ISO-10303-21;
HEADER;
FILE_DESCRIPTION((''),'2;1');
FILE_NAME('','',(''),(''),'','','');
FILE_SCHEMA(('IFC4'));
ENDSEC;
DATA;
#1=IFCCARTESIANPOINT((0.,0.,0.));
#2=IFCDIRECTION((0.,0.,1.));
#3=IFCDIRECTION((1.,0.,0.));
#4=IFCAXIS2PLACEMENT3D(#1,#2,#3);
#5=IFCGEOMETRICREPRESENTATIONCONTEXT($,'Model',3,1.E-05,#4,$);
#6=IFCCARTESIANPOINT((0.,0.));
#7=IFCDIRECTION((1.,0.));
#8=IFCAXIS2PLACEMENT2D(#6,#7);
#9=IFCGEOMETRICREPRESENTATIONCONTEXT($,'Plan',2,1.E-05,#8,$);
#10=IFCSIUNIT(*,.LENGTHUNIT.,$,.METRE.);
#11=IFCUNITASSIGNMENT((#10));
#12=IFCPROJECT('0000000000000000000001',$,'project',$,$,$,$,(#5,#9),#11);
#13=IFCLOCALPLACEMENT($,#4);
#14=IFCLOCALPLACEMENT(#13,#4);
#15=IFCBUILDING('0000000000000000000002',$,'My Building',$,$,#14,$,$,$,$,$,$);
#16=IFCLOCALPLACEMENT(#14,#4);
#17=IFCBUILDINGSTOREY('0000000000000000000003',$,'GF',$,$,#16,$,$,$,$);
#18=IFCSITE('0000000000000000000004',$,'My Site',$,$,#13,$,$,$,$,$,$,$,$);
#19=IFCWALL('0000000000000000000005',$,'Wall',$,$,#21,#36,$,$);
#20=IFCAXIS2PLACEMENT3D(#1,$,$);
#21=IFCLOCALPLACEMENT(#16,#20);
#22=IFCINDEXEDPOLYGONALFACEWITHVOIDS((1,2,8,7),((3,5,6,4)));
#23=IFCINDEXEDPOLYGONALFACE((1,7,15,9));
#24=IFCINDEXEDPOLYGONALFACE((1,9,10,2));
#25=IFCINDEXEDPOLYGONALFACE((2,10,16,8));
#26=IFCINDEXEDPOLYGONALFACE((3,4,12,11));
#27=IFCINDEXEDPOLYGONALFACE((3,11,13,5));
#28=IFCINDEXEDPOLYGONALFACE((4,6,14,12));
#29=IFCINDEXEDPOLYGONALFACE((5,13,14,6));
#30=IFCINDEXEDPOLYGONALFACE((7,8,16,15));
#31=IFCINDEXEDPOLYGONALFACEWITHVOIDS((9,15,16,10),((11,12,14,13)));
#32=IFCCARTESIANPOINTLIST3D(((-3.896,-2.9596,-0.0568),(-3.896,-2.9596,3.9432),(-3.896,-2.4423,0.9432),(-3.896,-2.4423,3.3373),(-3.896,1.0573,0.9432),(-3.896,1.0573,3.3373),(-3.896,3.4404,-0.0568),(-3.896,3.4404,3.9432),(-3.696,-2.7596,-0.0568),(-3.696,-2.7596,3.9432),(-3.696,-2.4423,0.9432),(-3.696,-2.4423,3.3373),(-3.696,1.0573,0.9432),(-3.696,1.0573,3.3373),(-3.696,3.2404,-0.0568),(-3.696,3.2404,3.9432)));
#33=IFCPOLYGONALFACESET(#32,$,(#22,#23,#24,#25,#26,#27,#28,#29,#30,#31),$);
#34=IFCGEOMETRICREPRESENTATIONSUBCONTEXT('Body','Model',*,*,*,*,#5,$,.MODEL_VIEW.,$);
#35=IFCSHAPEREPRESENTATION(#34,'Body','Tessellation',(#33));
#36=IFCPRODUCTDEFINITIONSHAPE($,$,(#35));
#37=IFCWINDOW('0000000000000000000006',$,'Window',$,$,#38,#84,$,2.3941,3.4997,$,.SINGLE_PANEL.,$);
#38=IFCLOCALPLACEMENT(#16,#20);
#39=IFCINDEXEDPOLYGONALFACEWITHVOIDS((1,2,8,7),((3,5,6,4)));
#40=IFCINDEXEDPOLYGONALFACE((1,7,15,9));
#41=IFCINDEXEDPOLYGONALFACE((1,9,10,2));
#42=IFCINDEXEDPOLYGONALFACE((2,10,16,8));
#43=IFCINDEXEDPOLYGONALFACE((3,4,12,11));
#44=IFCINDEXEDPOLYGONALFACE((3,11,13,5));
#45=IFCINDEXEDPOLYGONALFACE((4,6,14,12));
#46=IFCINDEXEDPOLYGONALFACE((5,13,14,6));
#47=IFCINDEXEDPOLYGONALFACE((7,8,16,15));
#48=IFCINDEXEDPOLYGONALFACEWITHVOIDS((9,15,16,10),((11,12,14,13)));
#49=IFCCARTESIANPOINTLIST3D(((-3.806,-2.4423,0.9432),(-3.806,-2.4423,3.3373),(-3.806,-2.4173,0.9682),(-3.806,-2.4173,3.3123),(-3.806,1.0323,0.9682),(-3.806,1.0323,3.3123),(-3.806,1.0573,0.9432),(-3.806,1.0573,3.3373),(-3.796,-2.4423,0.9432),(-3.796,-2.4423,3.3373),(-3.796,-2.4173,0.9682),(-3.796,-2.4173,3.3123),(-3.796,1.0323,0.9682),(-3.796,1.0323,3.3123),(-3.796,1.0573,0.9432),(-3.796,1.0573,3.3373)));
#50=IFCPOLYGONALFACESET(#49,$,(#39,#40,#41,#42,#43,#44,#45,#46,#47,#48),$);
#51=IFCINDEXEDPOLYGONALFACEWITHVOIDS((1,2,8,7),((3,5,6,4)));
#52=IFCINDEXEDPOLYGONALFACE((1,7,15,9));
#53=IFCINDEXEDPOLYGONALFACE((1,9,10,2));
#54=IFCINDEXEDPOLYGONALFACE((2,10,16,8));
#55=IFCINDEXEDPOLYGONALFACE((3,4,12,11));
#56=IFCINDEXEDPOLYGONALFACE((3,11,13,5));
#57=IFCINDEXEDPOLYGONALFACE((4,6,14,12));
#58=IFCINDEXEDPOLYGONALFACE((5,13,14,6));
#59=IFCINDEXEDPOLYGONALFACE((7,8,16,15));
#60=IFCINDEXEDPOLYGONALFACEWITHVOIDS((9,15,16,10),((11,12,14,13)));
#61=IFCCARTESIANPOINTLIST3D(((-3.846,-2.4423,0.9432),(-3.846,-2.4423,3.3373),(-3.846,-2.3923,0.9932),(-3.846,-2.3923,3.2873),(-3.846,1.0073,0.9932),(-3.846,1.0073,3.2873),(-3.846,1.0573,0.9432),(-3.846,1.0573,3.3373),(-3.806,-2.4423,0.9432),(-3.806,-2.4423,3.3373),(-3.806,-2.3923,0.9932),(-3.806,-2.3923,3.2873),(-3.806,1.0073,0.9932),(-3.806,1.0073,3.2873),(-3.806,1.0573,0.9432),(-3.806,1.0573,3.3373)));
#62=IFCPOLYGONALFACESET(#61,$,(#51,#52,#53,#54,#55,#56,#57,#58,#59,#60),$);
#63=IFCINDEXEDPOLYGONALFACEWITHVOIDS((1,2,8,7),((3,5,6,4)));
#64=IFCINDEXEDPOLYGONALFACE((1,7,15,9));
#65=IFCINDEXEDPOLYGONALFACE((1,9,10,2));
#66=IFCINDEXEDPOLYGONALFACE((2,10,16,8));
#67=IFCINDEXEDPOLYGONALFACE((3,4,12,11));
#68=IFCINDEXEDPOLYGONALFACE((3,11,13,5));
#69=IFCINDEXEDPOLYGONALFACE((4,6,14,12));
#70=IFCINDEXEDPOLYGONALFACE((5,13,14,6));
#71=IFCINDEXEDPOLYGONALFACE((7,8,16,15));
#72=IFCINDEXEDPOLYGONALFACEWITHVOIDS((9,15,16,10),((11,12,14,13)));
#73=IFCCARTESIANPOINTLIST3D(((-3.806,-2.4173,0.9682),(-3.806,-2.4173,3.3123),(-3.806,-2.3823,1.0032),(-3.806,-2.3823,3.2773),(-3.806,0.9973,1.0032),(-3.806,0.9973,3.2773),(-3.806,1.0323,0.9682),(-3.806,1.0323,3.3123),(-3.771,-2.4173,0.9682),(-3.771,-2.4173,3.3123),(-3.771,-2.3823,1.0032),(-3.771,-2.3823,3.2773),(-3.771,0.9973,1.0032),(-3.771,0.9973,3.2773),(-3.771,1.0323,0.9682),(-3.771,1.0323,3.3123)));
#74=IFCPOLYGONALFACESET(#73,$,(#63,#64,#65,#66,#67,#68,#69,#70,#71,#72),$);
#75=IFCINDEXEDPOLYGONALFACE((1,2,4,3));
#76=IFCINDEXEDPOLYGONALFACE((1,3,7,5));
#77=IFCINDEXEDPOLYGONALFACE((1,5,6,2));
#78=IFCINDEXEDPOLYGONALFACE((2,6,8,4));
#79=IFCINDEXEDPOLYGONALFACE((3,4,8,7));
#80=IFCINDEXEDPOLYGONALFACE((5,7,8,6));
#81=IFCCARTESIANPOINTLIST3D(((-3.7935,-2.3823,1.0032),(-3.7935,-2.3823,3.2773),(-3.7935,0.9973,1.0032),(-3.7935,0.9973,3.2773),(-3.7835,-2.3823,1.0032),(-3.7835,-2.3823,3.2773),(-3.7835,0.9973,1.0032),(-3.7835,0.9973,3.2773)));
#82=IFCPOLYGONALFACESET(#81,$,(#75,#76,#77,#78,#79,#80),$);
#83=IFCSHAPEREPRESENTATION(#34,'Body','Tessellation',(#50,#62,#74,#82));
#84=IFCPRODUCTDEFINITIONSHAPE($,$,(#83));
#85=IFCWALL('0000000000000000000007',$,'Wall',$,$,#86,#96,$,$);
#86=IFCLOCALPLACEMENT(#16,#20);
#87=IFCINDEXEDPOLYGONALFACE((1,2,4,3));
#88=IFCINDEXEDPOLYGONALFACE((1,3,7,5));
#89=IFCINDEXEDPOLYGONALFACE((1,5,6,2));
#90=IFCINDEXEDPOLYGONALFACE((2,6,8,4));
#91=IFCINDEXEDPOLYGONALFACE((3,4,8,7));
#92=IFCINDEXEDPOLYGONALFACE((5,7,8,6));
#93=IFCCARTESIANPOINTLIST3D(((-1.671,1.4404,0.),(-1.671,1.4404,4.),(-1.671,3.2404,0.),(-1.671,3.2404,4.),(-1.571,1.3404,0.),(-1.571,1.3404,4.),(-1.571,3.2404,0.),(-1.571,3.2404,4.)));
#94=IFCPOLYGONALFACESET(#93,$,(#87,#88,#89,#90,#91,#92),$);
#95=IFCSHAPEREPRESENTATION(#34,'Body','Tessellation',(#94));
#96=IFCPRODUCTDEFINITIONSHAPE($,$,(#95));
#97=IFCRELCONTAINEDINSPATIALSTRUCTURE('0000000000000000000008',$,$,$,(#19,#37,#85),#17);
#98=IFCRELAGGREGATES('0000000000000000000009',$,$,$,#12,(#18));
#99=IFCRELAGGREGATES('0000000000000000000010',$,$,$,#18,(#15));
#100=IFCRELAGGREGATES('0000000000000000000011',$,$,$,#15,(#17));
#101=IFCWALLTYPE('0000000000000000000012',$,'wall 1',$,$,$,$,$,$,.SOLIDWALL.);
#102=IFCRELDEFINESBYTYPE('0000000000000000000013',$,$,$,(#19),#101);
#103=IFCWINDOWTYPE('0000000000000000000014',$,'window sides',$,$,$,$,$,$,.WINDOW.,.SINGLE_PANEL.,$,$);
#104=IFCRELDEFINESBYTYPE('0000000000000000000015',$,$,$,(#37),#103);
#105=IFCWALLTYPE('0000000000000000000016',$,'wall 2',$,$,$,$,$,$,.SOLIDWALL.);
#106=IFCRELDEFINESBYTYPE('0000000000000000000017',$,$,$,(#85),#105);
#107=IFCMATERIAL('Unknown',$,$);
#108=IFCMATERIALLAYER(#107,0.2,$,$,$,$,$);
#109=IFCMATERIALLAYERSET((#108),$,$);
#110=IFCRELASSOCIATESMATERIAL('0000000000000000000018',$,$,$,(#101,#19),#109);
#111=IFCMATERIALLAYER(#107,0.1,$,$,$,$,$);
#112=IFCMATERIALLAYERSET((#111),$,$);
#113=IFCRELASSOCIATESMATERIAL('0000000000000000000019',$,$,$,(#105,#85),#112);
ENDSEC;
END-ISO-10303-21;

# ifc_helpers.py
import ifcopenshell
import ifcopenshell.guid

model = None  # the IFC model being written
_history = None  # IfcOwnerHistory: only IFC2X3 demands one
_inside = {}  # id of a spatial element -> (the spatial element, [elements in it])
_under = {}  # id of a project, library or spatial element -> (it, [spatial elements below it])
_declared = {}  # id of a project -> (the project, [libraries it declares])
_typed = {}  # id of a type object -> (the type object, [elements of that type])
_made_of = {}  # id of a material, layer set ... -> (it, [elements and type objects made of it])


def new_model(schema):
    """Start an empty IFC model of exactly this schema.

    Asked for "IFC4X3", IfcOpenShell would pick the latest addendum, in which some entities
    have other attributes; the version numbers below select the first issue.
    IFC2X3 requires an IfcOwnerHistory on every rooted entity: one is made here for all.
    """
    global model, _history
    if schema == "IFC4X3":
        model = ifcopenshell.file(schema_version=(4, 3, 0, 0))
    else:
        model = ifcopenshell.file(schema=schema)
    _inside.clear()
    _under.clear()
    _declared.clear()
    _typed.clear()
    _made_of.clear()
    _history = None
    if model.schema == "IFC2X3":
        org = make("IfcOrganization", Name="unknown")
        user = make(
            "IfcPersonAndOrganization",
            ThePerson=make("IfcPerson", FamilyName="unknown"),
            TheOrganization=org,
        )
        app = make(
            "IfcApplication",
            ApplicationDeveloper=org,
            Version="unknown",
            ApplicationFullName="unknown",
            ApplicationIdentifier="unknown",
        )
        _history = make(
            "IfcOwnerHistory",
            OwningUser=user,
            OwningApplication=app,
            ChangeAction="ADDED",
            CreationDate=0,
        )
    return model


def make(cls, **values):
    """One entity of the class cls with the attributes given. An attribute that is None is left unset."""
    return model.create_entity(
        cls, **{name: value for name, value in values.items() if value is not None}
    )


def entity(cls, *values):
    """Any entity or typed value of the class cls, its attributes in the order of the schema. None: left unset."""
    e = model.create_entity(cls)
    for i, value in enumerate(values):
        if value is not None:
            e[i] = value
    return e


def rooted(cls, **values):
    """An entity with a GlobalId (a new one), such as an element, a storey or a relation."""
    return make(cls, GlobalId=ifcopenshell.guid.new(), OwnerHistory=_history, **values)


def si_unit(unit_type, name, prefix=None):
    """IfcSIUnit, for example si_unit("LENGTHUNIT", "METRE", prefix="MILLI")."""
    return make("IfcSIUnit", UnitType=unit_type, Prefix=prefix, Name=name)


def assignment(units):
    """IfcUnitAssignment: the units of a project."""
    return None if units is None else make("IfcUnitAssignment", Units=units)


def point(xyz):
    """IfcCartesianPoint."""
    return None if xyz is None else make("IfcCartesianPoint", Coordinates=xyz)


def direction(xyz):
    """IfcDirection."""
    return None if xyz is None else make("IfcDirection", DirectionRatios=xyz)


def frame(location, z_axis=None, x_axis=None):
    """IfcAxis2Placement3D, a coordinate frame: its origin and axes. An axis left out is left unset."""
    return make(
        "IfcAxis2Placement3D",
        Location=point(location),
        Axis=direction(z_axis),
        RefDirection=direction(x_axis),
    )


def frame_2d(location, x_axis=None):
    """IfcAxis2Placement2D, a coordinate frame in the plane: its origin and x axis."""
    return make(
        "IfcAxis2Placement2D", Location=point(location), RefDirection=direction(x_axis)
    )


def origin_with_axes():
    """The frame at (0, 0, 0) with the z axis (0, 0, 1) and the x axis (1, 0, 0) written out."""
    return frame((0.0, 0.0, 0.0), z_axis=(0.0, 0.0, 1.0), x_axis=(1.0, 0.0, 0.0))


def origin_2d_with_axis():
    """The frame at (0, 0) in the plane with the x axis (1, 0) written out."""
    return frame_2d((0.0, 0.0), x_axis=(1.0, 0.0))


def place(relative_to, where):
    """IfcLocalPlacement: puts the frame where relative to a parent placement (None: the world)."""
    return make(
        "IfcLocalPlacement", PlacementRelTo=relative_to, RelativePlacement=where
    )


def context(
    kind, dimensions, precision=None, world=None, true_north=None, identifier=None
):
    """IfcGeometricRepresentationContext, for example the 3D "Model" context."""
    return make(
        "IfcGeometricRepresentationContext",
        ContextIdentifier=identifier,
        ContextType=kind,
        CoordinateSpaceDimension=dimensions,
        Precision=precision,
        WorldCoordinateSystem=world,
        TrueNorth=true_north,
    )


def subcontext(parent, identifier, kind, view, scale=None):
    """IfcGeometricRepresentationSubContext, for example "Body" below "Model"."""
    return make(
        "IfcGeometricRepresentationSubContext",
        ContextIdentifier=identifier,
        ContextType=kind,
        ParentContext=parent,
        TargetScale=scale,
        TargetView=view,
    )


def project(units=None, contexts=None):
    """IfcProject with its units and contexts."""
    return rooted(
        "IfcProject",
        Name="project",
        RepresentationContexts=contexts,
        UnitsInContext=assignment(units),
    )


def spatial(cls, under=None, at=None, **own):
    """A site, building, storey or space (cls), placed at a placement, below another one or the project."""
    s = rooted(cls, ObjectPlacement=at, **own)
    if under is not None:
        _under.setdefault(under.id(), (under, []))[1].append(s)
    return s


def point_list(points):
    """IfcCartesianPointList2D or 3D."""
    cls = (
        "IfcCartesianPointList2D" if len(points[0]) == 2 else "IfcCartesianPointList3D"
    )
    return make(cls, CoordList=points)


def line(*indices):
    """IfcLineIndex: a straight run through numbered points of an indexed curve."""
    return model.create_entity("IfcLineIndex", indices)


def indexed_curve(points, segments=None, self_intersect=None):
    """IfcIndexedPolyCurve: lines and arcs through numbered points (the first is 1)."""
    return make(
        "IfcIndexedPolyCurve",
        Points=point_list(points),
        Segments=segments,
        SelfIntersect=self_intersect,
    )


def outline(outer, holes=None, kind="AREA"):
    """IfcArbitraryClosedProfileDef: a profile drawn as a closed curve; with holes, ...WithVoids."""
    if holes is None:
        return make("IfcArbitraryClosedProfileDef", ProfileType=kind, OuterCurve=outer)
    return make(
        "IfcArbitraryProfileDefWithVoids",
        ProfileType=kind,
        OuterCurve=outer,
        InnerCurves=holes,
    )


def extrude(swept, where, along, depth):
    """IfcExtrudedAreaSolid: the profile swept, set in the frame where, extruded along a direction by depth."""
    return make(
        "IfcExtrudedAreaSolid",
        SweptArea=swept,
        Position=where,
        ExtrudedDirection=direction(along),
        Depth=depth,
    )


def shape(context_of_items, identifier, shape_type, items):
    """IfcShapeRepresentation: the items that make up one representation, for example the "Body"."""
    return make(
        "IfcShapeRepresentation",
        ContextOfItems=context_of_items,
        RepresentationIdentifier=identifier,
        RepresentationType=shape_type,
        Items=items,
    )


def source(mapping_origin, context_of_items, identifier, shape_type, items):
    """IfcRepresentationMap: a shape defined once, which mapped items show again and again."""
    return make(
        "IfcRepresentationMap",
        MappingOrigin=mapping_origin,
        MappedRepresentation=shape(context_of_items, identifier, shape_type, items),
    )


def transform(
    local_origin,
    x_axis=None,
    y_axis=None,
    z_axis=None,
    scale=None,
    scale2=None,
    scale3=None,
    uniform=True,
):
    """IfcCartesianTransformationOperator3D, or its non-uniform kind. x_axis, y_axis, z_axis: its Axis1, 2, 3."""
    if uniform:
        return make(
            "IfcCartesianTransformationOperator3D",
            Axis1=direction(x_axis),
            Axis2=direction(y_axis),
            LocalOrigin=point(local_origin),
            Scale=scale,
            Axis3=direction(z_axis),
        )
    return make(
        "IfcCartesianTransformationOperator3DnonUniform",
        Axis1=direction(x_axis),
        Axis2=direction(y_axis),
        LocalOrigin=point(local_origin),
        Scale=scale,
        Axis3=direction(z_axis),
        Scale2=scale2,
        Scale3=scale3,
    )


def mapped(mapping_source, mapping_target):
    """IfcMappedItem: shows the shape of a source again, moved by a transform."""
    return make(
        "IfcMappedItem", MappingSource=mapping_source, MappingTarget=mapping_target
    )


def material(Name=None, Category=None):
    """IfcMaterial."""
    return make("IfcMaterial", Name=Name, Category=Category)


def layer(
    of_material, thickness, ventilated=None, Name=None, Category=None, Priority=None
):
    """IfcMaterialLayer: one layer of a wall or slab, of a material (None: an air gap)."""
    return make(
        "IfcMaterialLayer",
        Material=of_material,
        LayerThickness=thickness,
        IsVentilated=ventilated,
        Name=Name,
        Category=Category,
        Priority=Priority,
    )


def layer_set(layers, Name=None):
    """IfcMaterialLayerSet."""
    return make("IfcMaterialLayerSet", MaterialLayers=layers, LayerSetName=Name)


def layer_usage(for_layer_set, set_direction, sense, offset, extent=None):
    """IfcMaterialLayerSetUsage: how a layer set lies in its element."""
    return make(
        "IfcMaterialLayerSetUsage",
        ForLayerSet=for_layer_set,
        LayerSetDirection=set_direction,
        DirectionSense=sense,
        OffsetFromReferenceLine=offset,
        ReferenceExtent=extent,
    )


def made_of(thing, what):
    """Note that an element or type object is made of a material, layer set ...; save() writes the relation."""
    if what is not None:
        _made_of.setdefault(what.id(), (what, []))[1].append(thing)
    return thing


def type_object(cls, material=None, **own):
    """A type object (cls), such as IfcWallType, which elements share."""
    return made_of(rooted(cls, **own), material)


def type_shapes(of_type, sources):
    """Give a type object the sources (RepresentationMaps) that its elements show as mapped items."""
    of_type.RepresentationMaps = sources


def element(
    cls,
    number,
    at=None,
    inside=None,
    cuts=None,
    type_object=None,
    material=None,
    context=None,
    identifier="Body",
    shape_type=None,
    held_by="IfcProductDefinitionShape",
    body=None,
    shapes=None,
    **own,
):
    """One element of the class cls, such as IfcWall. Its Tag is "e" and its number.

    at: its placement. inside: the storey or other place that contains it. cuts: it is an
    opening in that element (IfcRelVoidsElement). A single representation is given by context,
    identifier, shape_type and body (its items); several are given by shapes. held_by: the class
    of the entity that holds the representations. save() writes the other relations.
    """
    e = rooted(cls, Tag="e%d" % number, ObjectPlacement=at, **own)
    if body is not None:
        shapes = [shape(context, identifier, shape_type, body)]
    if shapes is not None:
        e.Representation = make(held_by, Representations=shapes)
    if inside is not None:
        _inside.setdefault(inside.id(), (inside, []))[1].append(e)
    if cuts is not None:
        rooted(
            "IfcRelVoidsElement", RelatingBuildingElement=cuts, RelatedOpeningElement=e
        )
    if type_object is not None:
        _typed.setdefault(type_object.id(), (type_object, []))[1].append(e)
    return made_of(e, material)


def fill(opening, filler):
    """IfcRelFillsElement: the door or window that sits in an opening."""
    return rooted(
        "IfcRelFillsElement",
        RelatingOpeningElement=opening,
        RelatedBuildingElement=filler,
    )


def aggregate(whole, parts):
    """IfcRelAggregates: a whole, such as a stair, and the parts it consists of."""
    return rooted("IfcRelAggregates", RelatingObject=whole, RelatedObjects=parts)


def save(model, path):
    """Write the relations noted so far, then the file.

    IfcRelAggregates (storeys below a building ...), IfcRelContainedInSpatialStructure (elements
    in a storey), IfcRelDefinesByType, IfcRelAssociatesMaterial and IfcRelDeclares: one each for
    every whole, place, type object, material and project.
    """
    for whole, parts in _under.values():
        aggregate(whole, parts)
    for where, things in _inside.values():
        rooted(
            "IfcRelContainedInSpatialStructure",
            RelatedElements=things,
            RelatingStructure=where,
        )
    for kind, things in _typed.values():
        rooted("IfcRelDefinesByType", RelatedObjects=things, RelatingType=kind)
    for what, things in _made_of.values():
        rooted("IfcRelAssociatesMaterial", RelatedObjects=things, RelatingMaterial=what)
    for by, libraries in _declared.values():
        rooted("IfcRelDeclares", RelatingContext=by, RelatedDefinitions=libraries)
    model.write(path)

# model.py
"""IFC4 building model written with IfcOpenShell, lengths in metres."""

from ifc_helpers import new_model, entity, si_unit, frame, origin_with_axes, origin_2d_with_axis, place, context, subcontext, project, spatial, line, indexed_curve, outline, extrude, shape, source, transform, mapped, material, layer, layer_set, layer_usage, type_object, type_shapes, element, fill, save


model = new_model("IFC4")

# Units and contexts
model_context = context("Model", 3, precision=1e-05, world=origin_with_axes())
plan_context = context("Plan", 2, precision=1e-05, world=origin_2d_with_axis())
body_context_1 = subcontext(model_context, "Body", "Model", "MODEL_VIEW")
body_context_2 = subcontext(plan_context, "Body", "Plan", "PLAN_VIEW")
ifc_project = project(units=[si_unit("LENGTHUNIT", "METRE")], contexts=[model_context, plan_context])

# Site, building, storey
site_placement = place(None, origin_with_axes())
site = spatial("IfcSite", under=ifc_project, at=site_placement, Name="My Site")
building_placement = place(site_placement, origin_with_axes())
building = spatial("IfcBuilding", under=site, at=building_placement, Name="My Building")
storey_placement = place(building_placement, origin_with_axes())
storey = spatial("IfcBuildingStorey", under=building, at=storey_placement, Name="GF")

# Shared definitions
ifc_material = material(Name="Unknown")

# Shared definitions
ifc_layer_1 = layer(ifc_material, 0.2)
ifc_layer_set_1 = layer_set([ifc_layer_1])
wall_type_1 = type_object("IfcWallType", Name="wall 1", PredefinedType="SOLIDWALL", material=ifc_layer_set_1)

# Wall, opening, window
ifc_layer_usage_1 = layer_usage(ifc_layer_set_1, "AXIS2", "POSITIVE", 0.0)
wall_1_placement = place(storey_placement, frame((-3.696, -2.7596, -0.0568), z_axis=(0.0, 0.0, 1.0), x_axis=(0.0, 1.0, 0.0)))
wall_1 = element("IfcWall", 1, at=wall_1_placement, inside=storey, type_object=wall_type_1, material=ifc_layer_usage_1, Name="Wall", context=body_context_1, shape_type="SweptSolid", body=[
    extrude(outline(indexed_curve([(0.0, 0.0), (-0.2, 0.2), (6.2, 0.2), (6.0, 0.0)], segments=[line(1, 2, 3, 4, 1)])), origin_with_axes(), (0.0, 0.0, 1.0), 4.0),
])
shared_shape_1 = source(origin_with_axes(), body_context_1, "Body", "SweptSolid", [
    extrude(outline(indexed_curve([(0.0, 0.0), (3.4997, 0.0), (3.4997, 2.3941), (0.0, 2.3941)], segments=[line(1, 2, 3, 4, 1)])), frame((0.0, -0.6, 0.0), z_axis=(0.0, -1.0, 0.0), x_axis=(1.0, 0.0, 0.0)), (0.0, 0.0, -1.0), 1.2),
])
opening_1_placement = place(wall_1_placement, frame((3.8169, 0.2, 1.0), z_axis=(0.0, 0.0, 1.0), x_axis=(-1.0, 0.0, 0.0)))
opening_1 = element("IfcOpeningElement", 2, at=opening_1_placement, cuts=wall_1, PredefinedType="OPENING", context=body_context_1, shape_type="MappedRepresentation", body=[
    mapped(shared_shape_1, transform((0.0, 0.0, 0.0), x_axis=(1.0, 0.0, 0.0), y_axis=(0.0, 1.0, 0.0), z_axis=(0.0, 0.0, 1.0), scale=1.0)),
])
window_type_1 = type_object("IfcWindowType", Name="window sides", PartitioningType="SINGLE_PANEL", PredefinedType="WINDOW")
shared_shape_2 = source(origin_with_axes(), body_context_1, "Body", "SweptSolid", [
    extrude(outline(indexed_curve([(0.0, 0.0), (3.4997, 0.0), (3.4997, 2.3941), (0.0, 2.3941)], segments=[line(1, 2, 3, 4, 1)]), holes=[indexed_curve([(0.025, 0.025), (3.4747, 0.025), (3.4747, 2.3691), (0.025, 2.3691)], segments=[line(1, 2, 3, 4, 1)])]), frame((0.0, 0.09, 0.0), z_axis=(0.0, -1.0, 0.0), x_axis=(1.0, 0.0, 0.0)), (0.0, 0.0, -1.0), 0.01),
    extrude(outline(indexed_curve([(0.0, 0.0), (3.4997, 0.0), (3.4997, 2.3941), (0.0, 2.3941)], segments=[line(1, 2, 3, 4, 1)]), holes=[indexed_curve([(0.05, 0.05), (3.4497, 0.05), (3.4497, 2.3441), (0.05, 2.3441)], segments=[line(1, 2, 3, 4, 1)])]), frame((0.0, 0.05, 0.0), z_axis=(0.0, -1.0, 0.0), x_axis=(1.0, 0.0, 0.0)), (0.0, 0.0, -1.0), 0.04),
    extrude(outline(indexed_curve([(0.0, 0.0), (3.4497, 0.0), (3.4497, 2.3441), (0.0, 2.3441)], segments=[line(1, 2, 3, 4, 1)]), holes=[indexed_curve([(0.035, 0.035), (3.4147, 0.035), (3.4147, 2.3091), (0.035, 2.3091)], segments=[line(1, 2, 3, 4, 1)])]), frame((0.025, 0.09, 0.025), z_axis=(0.0, -1.0, 0.0), x_axis=(1.0, 0.0, 0.0)), (0.0, 0.0, -1.0), 0.035),
    extrude(outline(indexed_curve([(0.035, 0.035), (3.4147, 0.035), (3.4147, 2.3091), (0.035, 2.3091)], segments=[line(1, 2, 3, 4, 1)])), frame((0.025, 0.1025, 0.025), z_axis=(0.0, -1.0, 0.0), x_axis=(1.0, 0.0, 0.0)), (0.0, 0.0, -1.0), 0.01),
])
shared_shape_3 = source(origin_with_axes(), body_context_2, "Body", "Curve2D", [
    entity("IfcIndexedPolyCurve", entity("IfcCartesianPointList2D", [[0.05, 0.05], [3.4497, 0.05]])),
    entity("IfcIndexedPolyCurve", entity("IfcCartesianPointList2D", [[0.0, 0.1], [0.025, 0.1], [0.025, 0.09], [0.05, 0.09], [0.05, 0.05], [0.0, 0.05]]), [entity("IfcLineIndex", [1, 2, 3, 4, 5, 6, 1])]),
    entity("IfcIndexedPolyCurve", entity("IfcCartesianPointList2D", [[3.4997, 0.1], [3.4747, 0.1], [3.4747, 0.09], [3.4497, 0.09], [3.4497, 0.05], [3.4997, 0.05]]), [entity("IfcLineIndex", [1, 2, 3, 4, 5, 6, 1])]),
    entity("IfcIndexedPolyCurve", entity("IfcCartesianPointList2D", [[0.025, 0.09], [0.06, 0.09], [0.06, 0.125], [0.025, 0.125]]), [entity("IfcLineIndex", [1, 2, 3, 4, 1])]),
    entity("IfcIndexedPolyCurve", entity("IfcCartesianPointList2D", [[3.4747, 0.09], [3.4397, 0.09], [3.4397, 0.125], [3.4747, 0.125]]), [entity("IfcLineIndex", [1, 2, 3, 4, 1])]),
    entity("IfcIndexedPolyCurve", entity("IfcCartesianPointList2D", [[0.06, 0.09], [3.4397, 0.09]])),
    entity("IfcIndexedPolyCurve", entity("IfcCartesianPointList2D", [[0.06, 0.125], [3.4397, 0.125]])),
    entity("IfcIndexedPolyCurve", entity("IfcCartesianPointList2D", [[0.06, 0.1075], [3.4397, 0.1075]])),
])
type_shapes(window_type_1, [shared_shape_2, shared_shape_3])
window_1_placement = place(opening_1_placement, frame((0.0, 0.0, 0.0), z_axis=(0.0, 0.0, 1.0), x_axis=(1.0, 0.0, 0.0)))
window_1 = element("IfcWindow", 3, at=window_1_placement, inside=storey, type_object=window_type_1, Name="Window", OverallHeight=2.3941, OverallWidth=3.4997, PartitioningType="SINGLE_PANEL", shapes=[
    shape(body_context_1, "Body", "MappedRepresentation", [mapped(shared_shape_2, transform((0.0, 0.0, 0.0), x_axis=(1.0, 0.0, 0.0), y_axis=(0.0, 1.0, 0.0), z_axis=(0.0, 0.0, 1.0), scale=1.0))]),
    shape(body_context_2, "Body", "MappedRepresentation", [mapped(shared_shape_3, transform((0.0, 0.0, 0.0), x_axis=(1.0, 0.0, 0.0), y_axis=(0.0, 1.0, 0.0), z_axis=(0.0, 0.0, 1.0), scale=1.0))]),
])
fill(opening_1, window_1)

# Wall
ifc_layer_2 = layer(ifc_material, 0.1)
ifc_layer_set_2 = layer_set([ifc_layer_2])
ifc_layer_usage_2 = layer_usage(ifc_layer_set_2, "AXIS2", "POSITIVE", 0.0)
wall_type_2 = type_object("IfcWallType", Name="wall 2", PredefinedType="SOLIDWALL", material=ifc_layer_set_2)
wall_2_placement = place(storey_placement, frame((-1.671, 3.2404, 0.0), z_axis=(0.0, 0.0, 1.0), x_axis=(0.0, -1.0, 0.0)))
element("IfcWall", 4, at=wall_2_placement, inside=storey, type_object=wall_type_2, material=ifc_layer_usage_2, Name="Wall", context=body_context_1, shape_type="SweptSolid", body=[
    extrude(outline(indexed_curve([(0.0, 0.0), (0.0, 0.1), (1.9, 0.1), (1.8, 0.0)], segments=[line(1, 2, 3, 4, 1)])), origin_with_axes(), (0.0, 0.0, 1.0), 4.0),
])

save(model, "model.ifc")
